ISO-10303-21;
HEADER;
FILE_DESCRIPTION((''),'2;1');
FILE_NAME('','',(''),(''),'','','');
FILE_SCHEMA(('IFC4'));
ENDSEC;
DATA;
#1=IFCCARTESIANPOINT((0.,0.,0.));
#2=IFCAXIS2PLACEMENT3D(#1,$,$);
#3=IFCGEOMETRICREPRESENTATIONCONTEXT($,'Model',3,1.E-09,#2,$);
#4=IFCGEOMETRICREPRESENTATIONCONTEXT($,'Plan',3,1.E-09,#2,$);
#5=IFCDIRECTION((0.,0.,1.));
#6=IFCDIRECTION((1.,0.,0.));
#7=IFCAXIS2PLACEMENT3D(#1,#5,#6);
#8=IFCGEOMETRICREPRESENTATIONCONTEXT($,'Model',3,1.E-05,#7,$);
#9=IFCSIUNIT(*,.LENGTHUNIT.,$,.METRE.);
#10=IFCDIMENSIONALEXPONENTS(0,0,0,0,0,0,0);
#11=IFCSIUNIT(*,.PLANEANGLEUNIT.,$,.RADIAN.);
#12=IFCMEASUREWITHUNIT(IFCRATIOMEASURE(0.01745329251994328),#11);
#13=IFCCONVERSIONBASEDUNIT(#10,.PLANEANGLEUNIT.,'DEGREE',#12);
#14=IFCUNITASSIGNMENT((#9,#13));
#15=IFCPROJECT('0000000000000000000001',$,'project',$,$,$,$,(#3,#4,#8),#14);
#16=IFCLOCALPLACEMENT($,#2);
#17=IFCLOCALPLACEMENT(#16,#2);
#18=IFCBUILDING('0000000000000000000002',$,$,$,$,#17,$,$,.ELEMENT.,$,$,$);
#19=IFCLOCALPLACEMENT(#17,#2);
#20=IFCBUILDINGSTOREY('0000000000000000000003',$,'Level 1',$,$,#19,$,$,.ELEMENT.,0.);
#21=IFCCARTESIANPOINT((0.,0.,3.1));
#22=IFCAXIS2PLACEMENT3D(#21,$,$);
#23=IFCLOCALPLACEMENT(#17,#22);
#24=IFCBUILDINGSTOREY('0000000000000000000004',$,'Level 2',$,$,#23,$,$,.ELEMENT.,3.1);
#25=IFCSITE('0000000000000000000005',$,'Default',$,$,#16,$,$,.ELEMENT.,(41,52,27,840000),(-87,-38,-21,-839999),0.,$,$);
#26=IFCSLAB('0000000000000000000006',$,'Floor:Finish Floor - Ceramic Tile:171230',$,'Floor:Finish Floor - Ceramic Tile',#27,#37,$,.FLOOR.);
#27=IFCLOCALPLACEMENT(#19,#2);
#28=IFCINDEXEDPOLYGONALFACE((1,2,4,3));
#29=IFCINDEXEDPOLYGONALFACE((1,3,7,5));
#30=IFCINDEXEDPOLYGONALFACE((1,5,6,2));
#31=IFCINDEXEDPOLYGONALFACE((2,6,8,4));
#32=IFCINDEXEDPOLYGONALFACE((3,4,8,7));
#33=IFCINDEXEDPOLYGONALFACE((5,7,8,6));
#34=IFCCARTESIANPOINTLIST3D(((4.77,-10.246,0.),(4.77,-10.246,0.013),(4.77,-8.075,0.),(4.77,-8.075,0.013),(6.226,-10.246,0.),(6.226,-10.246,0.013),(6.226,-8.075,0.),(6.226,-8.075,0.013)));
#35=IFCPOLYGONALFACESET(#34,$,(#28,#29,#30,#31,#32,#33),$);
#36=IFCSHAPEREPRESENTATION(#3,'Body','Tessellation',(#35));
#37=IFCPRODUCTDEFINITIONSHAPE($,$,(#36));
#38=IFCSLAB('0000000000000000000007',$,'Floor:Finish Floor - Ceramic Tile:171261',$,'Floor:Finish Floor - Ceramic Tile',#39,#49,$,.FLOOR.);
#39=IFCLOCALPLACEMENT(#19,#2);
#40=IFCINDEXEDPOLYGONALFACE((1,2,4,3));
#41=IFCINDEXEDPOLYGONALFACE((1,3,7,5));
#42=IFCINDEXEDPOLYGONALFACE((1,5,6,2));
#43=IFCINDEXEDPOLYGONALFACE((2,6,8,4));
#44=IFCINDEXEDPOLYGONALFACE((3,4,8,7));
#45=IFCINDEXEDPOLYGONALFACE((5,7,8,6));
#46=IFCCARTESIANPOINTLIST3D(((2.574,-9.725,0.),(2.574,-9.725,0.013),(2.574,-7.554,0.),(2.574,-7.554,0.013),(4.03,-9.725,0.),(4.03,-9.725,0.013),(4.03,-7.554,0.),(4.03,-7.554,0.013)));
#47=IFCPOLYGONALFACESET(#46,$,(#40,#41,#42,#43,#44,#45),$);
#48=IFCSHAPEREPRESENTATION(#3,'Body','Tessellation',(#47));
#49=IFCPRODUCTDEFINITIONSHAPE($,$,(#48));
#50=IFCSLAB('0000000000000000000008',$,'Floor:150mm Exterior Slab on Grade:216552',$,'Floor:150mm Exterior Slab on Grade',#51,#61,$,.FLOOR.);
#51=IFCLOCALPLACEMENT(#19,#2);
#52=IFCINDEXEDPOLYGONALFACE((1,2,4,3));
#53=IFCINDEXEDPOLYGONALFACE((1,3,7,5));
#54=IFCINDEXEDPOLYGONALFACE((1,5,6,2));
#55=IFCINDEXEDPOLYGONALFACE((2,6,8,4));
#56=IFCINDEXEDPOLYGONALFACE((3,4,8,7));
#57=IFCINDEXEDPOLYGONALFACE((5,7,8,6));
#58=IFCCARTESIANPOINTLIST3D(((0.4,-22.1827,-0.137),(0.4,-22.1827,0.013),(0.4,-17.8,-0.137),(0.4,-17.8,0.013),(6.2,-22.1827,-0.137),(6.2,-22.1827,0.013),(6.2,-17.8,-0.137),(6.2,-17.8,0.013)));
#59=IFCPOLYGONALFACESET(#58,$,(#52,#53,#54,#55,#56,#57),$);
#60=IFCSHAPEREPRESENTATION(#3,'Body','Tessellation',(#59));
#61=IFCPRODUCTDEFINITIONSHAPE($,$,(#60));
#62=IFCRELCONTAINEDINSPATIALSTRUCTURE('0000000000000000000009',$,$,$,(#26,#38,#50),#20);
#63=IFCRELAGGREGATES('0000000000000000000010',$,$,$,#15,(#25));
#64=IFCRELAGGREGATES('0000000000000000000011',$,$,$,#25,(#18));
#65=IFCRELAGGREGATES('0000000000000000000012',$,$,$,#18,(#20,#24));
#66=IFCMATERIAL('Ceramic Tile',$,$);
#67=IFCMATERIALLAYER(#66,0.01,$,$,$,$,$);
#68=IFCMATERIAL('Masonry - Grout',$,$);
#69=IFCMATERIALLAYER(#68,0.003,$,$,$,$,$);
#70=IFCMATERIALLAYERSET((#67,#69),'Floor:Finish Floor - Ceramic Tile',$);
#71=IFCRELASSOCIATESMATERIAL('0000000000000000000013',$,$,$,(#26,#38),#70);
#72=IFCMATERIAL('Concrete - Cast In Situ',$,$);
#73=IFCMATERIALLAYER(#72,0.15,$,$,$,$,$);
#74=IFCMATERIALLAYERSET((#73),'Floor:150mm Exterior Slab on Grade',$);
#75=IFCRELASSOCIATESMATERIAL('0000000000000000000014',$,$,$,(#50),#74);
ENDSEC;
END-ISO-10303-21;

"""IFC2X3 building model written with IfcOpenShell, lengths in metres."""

from ifc_helpers import new_model, entity, si_unit, converted_unit, frame, frame_2d, origin, origin_with_axes, origin_2d_with_axis, place, context, project, spatial, rectangle, extrude, material, layer, layer_set, layer_usage, element, save


model = new_model("IFC2X3")

# Units and contexts
model_context_1 = context("Model", 3, precision=1e-09, world=origin())
plan_context = context("Plan", 3, precision=1e-09, world=origin())
model_context_2 = context("Model", 3, precision=1e-05, world=origin_with_axes())
ifc_project = project(units=[si_unit("LENGTHUNIT", "METRE"), converted_unit("PLANEANGLEUNIT", "DEGREE", entity("IfcRatioMeasure", 0.01745329251994328), si_unit("PLANEANGLEUNIT", "RADIAN"), dimensions=[0, 0, 0, 0, 0, 0, 0])], contexts=[model_context_1, plan_context, model_context_2])

# Site, building, storey
site_placement = place(None, origin())
site = spatial("IfcSite", under=ifc_project, at=site_placement, Name="Default", CompositionType="ELEMENT", RefLatitude=(41, 52, 27, 840000), RefLongitude=(-87, -38, -21, -839999), RefElevation=0.0)
building_placement = place(site_placement, origin())
building = spatial("IfcBuilding", under=site, at=building_placement, CompositionType="ELEMENT")
storey_1_placement = place(building_placement, origin())
storey_1 = spatial("IfcBuildingStorey", under=building, at=storey_1_placement, Name="Level 1", CompositionType="ELEMENT", Elevation=0.0)

# Slabs
ifc_material_1 = material(Name="Ceramic Tile")
ifc_layer_1 = layer(ifc_material_1, 0.01)
ifc_material_2 = material(Name="Masonry - Grout")
ifc_layer_2 = layer(ifc_material_2, 0.003)
ifc_layer_set_1 = layer_set([ifc_layer_1, ifc_layer_2], Name="Floor:Finish Floor - Ceramic Tile")
ifc_layer_usage_1 = layer_usage(ifc_layer_set_1, "AXIS3", "POSITIVE", 0.0)
slab_1_placement = place(storey_1_placement, frame((4.77, -10.246, 0.0)))
element("IfcSlab", 1, at=slab_1_placement, inside=storey_1, material=ifc_layer_usage_1, Name="Floor:Finish Floor - Ceramic Tile:171230", ObjectType="Floor:Finish Floor - Ceramic Tile", PredefinedType="FLOOR", context=model_context_1, shape_type="SweptSolid", body=[
    extrude(rectangle(XDim=1.456, YDim=2.171, at=frame_2d((0.0, 0.0), x_axis=(-1.0, 0.0))), frame((0.728, 1.0855, 0.013), z_axis=(0.0, 0.0, -1.0), x_axis=(-1.0, 0.0, 0.0)), (0.0, 0.0, 1.0), 0.013),
])
ifc_layer_usage_2 = layer_usage(ifc_layer_set_1, "AXIS3", "POSITIVE", 0.0)
slab_2_placement = place(storey_1_placement, frame((2.574, -9.725, 0.0)))
element("IfcSlab", 2, at=slab_2_placement, inside=storey_1, material=ifc_layer_usage_2, Name="Floor:Finish Floor - Ceramic Tile:171261", ObjectType="Floor:Finish Floor - Ceramic Tile", PredefinedType="FLOOR", context=model_context_1, shape_type="SweptSolid", body=[
    extrude(rectangle(XDim=2.171, YDim=1.456, at=frame_2d((0.0, 0.0), x_axis=(0.0, -1.0))), frame((0.728, 1.0855, 0.013), z_axis=(0.0, 0.0, -1.0), x_axis=(-1.0, 0.0, 0.0)), (0.0, 0.0, 1.0), 0.013),
])
ifc_material_3 = material(Name="Concrete - Cast In Situ")
ifc_layer_3 = layer(ifc_material_3, 0.15)
ifc_layer_set_2 = layer_set([ifc_layer_3], Name="Floor:150mm Exterior Slab on Grade")
ifc_layer_usage_3 = layer_usage(ifc_layer_set_2, "AXIS3", "POSITIVE", 0.0)
slab_3_placement = place(storey_1_placement, frame((0.4, -22.1827, -0.137)))
element("IfcSlab", 3, at=slab_3_placement, inside=storey_1, material=ifc_layer_usage_3, Name="Floor:150mm Exterior Slab on Grade:216552", ObjectType="Floor:150mm Exterior Slab on Grade", PredefinedType="FLOOR", context=model_context_1, shape_type="SweptSolid", body=[
    extrude(rectangle(XDim=5.8, YDim=4.3827, at=origin_2d_with_axis()), frame((2.9, 2.1914, 0.15), z_axis=(0.0, 0.0, -1.0), x_axis=(-1.0, 0.0, 0.0)), (0.0, 0.0, 1.0), 0.15),
])

# Shared definitions
storey_2_placement = place(building_placement, frame((0.0, 0.0, 3.1)))
storey_2 = spatial("IfcBuildingStorey", under=building, at=storey_2_placement, Name="Level 2", CompositionType="ELEMENT", Elevation=3.1)

save(model, "model.ifc")
